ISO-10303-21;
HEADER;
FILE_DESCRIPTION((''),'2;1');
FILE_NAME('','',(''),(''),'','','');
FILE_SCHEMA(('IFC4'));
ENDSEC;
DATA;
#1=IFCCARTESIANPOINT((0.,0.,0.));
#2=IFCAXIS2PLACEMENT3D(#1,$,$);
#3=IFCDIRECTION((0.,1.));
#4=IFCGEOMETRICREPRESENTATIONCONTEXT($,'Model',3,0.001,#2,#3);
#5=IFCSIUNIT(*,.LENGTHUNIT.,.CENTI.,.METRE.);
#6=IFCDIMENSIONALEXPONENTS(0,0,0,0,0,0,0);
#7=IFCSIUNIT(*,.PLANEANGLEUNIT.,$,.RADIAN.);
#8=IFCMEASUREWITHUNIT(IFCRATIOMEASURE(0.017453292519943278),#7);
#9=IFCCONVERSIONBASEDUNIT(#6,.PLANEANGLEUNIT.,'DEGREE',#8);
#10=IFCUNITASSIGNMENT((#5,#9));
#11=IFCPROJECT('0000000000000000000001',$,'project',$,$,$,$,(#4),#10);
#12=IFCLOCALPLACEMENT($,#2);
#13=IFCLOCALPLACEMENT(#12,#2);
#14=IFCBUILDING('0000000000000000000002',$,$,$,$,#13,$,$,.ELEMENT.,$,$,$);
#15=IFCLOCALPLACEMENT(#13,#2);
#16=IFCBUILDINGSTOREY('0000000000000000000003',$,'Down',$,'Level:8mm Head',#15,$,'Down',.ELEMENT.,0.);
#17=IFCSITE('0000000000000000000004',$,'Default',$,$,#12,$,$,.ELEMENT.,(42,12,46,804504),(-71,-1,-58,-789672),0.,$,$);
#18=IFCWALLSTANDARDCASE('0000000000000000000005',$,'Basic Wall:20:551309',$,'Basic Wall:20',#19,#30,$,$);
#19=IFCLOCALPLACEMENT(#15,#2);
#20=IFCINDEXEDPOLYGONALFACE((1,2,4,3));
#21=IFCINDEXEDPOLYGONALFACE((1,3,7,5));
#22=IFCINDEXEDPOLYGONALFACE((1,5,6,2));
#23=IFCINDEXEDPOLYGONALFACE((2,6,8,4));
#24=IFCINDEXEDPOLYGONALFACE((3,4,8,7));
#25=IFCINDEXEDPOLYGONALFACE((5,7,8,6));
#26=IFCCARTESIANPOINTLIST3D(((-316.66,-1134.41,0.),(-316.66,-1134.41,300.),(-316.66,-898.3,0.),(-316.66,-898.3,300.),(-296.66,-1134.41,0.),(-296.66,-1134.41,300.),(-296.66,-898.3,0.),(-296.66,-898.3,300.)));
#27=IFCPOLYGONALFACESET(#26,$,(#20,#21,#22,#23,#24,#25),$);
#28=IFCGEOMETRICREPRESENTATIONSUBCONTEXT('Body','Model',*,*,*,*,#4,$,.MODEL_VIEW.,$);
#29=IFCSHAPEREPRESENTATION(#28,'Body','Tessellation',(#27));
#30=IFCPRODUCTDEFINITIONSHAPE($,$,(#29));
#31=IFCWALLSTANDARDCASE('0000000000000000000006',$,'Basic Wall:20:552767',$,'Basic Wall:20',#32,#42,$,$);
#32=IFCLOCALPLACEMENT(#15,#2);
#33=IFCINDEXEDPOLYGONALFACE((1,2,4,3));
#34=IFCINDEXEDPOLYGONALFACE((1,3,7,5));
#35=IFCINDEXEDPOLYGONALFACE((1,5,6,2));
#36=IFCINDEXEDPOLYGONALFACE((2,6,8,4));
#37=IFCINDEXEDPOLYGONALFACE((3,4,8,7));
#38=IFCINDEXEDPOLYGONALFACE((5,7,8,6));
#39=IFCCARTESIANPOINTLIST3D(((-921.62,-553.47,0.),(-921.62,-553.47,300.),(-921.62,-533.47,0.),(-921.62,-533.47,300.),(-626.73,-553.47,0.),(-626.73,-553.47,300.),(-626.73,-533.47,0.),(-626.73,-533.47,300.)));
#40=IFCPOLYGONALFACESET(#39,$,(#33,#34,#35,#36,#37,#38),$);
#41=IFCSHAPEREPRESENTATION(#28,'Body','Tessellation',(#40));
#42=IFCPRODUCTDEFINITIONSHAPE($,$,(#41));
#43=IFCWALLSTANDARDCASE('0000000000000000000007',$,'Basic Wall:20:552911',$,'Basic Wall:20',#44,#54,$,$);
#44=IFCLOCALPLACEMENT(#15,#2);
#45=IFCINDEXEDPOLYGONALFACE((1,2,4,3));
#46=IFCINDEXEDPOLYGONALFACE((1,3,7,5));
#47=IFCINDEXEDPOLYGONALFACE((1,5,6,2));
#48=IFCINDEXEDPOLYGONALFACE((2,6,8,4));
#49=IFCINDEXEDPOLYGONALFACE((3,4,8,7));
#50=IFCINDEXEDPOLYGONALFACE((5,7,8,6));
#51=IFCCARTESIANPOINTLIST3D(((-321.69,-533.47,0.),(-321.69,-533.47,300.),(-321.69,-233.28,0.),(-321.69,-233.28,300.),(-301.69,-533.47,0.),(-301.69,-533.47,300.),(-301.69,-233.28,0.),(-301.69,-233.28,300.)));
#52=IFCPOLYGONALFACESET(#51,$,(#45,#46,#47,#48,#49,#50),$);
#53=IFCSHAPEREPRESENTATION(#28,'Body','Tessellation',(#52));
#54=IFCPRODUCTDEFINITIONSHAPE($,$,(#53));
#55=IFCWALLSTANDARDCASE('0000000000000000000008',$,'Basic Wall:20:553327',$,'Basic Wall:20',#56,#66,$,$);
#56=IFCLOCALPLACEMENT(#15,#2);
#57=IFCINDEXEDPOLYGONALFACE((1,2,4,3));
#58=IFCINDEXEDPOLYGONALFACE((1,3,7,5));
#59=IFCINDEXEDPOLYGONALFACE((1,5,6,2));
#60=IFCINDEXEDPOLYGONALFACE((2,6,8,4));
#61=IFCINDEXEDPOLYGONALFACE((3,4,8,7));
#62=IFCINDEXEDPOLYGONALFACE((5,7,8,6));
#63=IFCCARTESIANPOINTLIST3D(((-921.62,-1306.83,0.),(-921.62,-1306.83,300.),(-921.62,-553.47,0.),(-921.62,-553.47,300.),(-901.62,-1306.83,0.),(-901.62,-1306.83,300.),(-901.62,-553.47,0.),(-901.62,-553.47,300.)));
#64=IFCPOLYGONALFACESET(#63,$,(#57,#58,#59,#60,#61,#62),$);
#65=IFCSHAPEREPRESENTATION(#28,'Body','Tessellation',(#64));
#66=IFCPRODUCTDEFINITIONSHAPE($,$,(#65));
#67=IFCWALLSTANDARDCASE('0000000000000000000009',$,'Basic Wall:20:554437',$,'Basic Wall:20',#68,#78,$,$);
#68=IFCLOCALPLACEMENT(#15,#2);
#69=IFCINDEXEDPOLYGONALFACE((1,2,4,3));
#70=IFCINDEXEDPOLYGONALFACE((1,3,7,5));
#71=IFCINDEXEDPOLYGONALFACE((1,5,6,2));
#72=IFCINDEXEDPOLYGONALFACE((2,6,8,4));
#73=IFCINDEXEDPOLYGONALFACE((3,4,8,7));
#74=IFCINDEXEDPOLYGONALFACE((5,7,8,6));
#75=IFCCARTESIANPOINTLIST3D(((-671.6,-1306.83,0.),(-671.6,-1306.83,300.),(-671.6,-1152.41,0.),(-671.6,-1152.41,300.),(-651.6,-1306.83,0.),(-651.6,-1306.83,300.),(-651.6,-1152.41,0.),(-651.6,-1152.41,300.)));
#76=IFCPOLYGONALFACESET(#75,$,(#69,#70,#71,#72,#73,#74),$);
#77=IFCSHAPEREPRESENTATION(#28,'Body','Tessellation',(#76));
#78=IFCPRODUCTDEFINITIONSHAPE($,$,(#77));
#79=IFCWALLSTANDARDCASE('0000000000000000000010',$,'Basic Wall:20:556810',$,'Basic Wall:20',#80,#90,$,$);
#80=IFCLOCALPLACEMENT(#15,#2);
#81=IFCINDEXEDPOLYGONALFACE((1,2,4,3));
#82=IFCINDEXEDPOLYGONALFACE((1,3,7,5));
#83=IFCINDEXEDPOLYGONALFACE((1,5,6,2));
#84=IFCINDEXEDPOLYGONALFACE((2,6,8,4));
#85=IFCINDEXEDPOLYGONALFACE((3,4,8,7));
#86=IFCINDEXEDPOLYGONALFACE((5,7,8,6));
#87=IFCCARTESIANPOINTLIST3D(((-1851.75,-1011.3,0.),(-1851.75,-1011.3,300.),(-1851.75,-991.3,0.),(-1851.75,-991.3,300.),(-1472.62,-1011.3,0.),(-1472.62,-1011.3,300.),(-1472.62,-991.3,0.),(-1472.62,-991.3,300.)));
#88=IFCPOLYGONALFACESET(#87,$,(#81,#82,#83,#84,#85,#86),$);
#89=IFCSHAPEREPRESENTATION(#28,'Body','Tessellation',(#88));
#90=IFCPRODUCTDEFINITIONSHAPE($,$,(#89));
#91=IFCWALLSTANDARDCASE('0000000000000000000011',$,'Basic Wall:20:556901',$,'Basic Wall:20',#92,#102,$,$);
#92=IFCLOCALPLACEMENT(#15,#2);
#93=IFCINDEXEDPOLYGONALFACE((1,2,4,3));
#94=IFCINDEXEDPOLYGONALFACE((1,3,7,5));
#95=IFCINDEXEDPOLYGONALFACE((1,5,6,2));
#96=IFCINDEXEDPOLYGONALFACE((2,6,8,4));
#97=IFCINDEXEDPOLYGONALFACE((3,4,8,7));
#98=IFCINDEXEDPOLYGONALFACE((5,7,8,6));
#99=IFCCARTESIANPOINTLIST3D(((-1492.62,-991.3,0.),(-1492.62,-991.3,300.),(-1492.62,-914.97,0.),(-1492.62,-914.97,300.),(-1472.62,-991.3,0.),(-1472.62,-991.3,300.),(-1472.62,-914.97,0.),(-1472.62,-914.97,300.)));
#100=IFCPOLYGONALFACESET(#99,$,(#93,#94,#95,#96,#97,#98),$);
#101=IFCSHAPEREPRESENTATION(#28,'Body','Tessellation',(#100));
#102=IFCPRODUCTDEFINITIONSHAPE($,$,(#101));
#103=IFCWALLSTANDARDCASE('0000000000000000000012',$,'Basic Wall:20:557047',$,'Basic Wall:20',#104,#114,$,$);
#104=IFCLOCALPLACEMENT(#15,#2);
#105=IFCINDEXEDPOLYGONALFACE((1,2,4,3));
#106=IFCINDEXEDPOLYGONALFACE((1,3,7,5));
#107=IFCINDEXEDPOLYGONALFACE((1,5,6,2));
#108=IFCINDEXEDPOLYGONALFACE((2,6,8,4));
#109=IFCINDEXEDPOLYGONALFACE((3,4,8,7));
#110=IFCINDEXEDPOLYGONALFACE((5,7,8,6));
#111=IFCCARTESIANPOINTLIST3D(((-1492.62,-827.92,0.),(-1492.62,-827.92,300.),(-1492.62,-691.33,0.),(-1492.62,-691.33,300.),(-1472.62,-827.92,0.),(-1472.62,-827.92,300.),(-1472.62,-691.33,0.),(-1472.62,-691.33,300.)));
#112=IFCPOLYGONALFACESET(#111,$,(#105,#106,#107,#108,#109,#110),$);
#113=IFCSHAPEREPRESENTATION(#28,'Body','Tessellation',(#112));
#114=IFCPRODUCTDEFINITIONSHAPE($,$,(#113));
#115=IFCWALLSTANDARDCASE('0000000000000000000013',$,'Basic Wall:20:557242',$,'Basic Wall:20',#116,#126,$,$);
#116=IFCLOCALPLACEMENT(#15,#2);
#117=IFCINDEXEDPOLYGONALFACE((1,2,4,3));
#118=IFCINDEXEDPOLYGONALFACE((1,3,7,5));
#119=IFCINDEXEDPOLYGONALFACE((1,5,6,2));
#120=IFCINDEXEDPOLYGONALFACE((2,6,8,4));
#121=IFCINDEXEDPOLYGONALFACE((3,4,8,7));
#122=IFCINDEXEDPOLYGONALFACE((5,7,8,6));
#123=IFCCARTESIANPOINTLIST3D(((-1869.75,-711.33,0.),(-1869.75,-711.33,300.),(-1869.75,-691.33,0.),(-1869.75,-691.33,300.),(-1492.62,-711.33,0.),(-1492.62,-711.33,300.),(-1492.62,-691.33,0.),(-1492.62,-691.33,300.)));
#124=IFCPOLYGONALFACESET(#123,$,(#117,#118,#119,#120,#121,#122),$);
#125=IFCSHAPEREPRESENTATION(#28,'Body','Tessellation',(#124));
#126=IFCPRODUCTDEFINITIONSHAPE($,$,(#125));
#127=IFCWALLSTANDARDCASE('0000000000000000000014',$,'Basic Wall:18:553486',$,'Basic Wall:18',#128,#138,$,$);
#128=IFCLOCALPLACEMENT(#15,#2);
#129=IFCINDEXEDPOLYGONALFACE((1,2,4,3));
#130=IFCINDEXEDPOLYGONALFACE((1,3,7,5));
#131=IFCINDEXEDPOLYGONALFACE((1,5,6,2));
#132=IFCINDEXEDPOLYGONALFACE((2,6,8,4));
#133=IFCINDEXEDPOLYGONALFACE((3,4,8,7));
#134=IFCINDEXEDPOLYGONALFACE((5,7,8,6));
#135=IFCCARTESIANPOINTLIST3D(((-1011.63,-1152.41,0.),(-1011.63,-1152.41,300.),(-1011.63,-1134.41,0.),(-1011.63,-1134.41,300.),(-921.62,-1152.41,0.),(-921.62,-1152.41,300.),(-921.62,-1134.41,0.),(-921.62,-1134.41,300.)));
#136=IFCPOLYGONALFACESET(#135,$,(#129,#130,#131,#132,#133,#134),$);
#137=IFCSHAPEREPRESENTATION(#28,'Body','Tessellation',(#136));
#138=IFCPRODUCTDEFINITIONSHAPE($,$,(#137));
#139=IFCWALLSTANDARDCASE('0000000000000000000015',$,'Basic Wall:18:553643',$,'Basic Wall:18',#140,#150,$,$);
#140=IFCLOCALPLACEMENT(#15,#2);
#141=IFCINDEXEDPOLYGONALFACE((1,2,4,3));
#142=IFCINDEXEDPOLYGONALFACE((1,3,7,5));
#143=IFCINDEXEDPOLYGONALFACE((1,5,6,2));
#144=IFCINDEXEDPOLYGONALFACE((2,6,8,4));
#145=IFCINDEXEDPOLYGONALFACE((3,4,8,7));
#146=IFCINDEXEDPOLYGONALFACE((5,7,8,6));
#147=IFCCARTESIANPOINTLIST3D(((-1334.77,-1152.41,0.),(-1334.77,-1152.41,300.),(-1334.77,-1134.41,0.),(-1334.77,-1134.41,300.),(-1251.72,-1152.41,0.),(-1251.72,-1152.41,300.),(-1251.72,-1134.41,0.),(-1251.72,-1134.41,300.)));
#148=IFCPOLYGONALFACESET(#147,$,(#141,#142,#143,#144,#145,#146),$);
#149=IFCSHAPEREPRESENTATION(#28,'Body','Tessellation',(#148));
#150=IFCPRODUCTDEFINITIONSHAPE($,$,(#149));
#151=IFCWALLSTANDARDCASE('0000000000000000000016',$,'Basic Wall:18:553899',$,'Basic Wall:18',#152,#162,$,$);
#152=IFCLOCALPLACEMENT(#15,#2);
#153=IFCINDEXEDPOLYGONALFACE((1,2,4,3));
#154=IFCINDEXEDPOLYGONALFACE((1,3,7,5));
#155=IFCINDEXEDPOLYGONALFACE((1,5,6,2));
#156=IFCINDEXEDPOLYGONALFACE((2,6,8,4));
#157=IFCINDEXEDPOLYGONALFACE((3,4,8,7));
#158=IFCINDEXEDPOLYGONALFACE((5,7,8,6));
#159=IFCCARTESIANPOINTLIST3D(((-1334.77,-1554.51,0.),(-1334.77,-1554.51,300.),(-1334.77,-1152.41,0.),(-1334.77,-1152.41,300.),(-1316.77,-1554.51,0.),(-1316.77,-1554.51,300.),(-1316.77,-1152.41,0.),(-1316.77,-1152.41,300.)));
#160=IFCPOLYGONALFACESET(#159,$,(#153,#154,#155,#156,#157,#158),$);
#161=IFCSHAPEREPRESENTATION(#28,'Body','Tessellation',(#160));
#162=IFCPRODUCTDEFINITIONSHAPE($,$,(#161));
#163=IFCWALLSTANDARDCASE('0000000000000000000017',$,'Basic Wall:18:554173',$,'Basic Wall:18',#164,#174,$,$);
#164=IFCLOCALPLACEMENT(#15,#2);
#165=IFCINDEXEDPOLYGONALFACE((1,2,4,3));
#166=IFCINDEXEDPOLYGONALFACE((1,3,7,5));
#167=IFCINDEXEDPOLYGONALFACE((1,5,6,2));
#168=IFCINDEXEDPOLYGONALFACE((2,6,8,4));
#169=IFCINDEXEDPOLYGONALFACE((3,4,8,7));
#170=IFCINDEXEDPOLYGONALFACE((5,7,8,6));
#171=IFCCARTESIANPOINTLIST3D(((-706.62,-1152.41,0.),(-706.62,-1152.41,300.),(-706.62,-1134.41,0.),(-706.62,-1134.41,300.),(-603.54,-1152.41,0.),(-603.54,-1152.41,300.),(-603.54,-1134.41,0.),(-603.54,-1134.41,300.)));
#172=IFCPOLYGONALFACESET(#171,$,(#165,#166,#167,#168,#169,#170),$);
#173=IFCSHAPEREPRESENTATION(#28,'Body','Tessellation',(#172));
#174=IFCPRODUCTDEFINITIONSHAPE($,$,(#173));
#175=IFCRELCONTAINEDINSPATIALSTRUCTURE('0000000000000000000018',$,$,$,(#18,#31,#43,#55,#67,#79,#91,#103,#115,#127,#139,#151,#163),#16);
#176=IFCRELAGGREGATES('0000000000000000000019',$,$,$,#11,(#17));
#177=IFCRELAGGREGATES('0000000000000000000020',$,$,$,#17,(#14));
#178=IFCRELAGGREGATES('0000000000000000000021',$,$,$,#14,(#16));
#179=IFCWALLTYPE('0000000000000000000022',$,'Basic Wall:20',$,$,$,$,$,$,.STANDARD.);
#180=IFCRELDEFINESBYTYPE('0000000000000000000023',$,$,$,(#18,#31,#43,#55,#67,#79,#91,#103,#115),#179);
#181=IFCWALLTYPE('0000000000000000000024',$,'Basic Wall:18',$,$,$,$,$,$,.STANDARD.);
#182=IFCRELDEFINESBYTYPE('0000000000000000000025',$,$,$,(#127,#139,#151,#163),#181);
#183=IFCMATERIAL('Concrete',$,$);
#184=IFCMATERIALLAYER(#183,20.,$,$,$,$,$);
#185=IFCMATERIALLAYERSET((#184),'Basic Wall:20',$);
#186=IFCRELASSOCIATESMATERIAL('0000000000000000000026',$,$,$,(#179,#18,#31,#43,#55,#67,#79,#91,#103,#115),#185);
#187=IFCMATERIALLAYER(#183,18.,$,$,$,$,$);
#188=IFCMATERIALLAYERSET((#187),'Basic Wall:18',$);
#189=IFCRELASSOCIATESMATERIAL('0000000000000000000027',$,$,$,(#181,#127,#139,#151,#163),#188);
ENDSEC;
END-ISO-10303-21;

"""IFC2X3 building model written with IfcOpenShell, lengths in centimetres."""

from ifc_helpers import new_model, entity, si_unit, converted_unit, direction, frame, frame_2d, origin, place, context, subcontext, project, spatial, rectangle, extrude, material, layer, layer_set, layer_usage, type_object, element, save


model = new_model("IFC2X3")

# Units and contexts
model_context = context("Model", 3, precision=0.001, world=origin(), true_north=direction((0.0, 1.0)))
body_context = subcontext(model_context, "Body", "Model", "MODEL_VIEW")
ifc_project = project(units=[si_unit("LENGTHUNIT", "METRE", prefix="CENTI"), converted_unit("PLANEANGLEUNIT", "DEGREE", entity("IfcRatioMeasure", 0.017453292519943278), si_unit("PLANEANGLEUNIT", "RADIAN"), dimensions=[0, 0, 0, 0, 0, 0, 0])], contexts=[model_context])

# Site, building, storey
site_placement = place(None, origin())
site = spatial("IfcSite", under=ifc_project, at=site_placement, Name="Default", CompositionType="ELEMENT", RefLatitude=(42, 12, 46, 804504), RefLongitude=(-71, -1, -58, -789672), RefElevation=0.0)
building_placement = place(site_placement, origin())
building = spatial("IfcBuilding", under=site, at=building_placement, CompositionType="ELEMENT")
storey_placement = place(building_placement, origin())
storey = spatial("IfcBuildingStorey", under=building, at=storey_placement, Name="Down", ObjectType="Level:8mm Head", LongName="Down", CompositionType="ELEMENT", Elevation=0.0)

# Walls
ifc_material = material(Name="Concrete")
ifc_layer_1 = layer(ifc_material, 20.0)
ifc_layer_set_1 = layer_set([ifc_layer_1], Name="Basic Wall:20")
ifc_layer_usage_1 = layer_usage(ifc_layer_set_1, "AXIS2", "POSITIVE", -10.0)
wall_type_1 = type_object("IfcWallType", Name="Basic Wall:20", PredefinedType="STANDARD", material=ifc_layer_set_1)
wall_1_placement = place(storey_placement, frame((-306.66, -898.3, 0.0), z_axis=(0.0, 0.0, 1.0), x_axis=(0.0, -1.0, 0.0)))
element("IfcWallStandardCase", 1, at=wall_1_placement, inside=storey, type_object=wall_type_1, material=ifc_layer_usage_1, Name="Basic Wall:20:551309", ObjectType="Basic Wall:20", context=body_context, shape_type="SweptSolid", body=[
    extrude(rectangle(XDim=236.11, YDim=20.0, at=frame_2d((118.05, 0.0), x_axis=(-1.0, 0.0))), origin(), (0.0, 0.0, 1.0), 300.0),
])
ifc_layer_usage_2 = layer_usage(ifc_layer_set_1, "AXIS2", "NEGATIVE", 10.0)
wall_2_placement = place(storey_placement, frame((-626.73, -543.47, 0.0), z_axis=(0.0, 0.0, 1.0), x_axis=(-1.0, 0.0, 0.0)))
element("IfcWallStandardCase", 2, at=wall_2_placement, inside=storey, type_object=wall_type_1, material=ifc_layer_usage_2, Name="Basic Wall:20:552767", ObjectType="Basic Wall:20", context=body_context, shape_type="SweptSolid", body=[
    extrude(rectangle(XDim=294.89, YDim=20.0, at=frame_2d((147.45, 0.0), x_axis=(-1.0, 0.0))), origin(), (0.0, 0.0, 1.0), 300.0),
])
ifc_layer_usage_3 = layer_usage(ifc_layer_set_1, "AXIS2", "NEGATIVE", 10.0)
wall_3_placement = place(storey_placement, frame((-311.69, -233.28, 0.0), z_axis=(0.0, 0.0, 1.0), x_axis=(0.0, -1.0, 0.0)))
element("IfcWallStandardCase", 3, at=wall_3_placement, inside=storey, type_object=wall_type_1, material=ifc_layer_usage_3, Name="Basic Wall:20:552911", ObjectType="Basic Wall:20", context=body_context, shape_type="SweptSolid", body=[
    extrude(rectangle(XDim=300.19, YDim=20.0, at=frame_2d((150.09, 0.0), x_axis=(-1.0, 0.0))), origin(), (0.0, 0.0, 1.0), 300.0),
])
ifc_layer_usage_4 = layer_usage(ifc_layer_set_1, "AXIS2", "POSITIVE", -10.0)
wall_4_placement = place(storey_placement, frame((-911.62, -553.47, 0.0), z_axis=(0.0, 0.0, 1.0), x_axis=(0.0, -1.0, 0.0)))
element("IfcWallStandardCase", 4, at=wall_4_placement, inside=storey, type_object=wall_type_1, material=ifc_layer_usage_4, Name="Basic Wall:20:553327", ObjectType="Basic Wall:20", context=body_context, shape_type="SweptSolid", body=[
    extrude(rectangle(XDim=753.36, YDim=20.0, at=frame_2d((376.68, 0.0), x_axis=(-1.0, 0.0))), origin(), (0.0, 0.0, 1.0), 300.0),
])
ifc_layer_usage_5 = layer_usage(ifc_layer_set_1, "AXIS2", "NEGATIVE", 10.0)
wall_5_placement = place(storey_placement, frame((-661.6, -1152.41, 0.0), z_axis=(0.0, 0.0, 1.0), x_axis=(0.0, -1.0, 0.0)))
element("IfcWallStandardCase", 5, at=wall_5_placement, inside=storey, type_object=wall_type_1, material=ifc_layer_usage_5, Name="Basic Wall:20:554437", ObjectType="Basic Wall:20", context=body_context, shape_type="SweptSolid", body=[
    extrude(rectangle(XDim=154.42, YDim=20.0, at=frame_2d((77.21, 0.0), x_axis=(-1.0, 0.0))), origin(), (0.0, 0.0, 1.0), 300.0),
])
ifc_layer_usage_6 = layer_usage(ifc_layer_set_1, "AXIS2", "POSITIVE", -10.0)
wall_6_placement = place(storey_placement, frame((-1851.75, -1001.3, 0.0)))
element("IfcWallStandardCase", 6, at=wall_6_placement, inside=storey, type_object=wall_type_1, material=ifc_layer_usage_6, Name="Basic Wall:20:556810", ObjectType="Basic Wall:20", context=body_context, shape_type="SweptSolid", body=[
    extrude(rectangle(XDim=379.13, YDim=20.0, at=frame_2d((189.56, 0.0), x_axis=(-1.0, 0.0))), origin(), (0.0, 0.0, 1.0), 300.0),
])
ifc_layer_usage_7 = layer_usage(ifc_layer_set_1, "AXIS2", "POSITIVE", -10.0)
wall_7_placement = place(storey_placement, frame((-1482.62, -991.3, 0.0), z_axis=(0.0, 0.0, 1.0), x_axis=(0.0, 1.0, 0.0)))
element("IfcWallStandardCase", 7, at=wall_7_placement, inside=storey, type_object=wall_type_1, material=ifc_layer_usage_7, Name="Basic Wall:20:556901", ObjectType="Basic Wall:20", context=body_context, shape_type="SweptSolid", body=[
    extrude(rectangle(XDim=76.33, YDim=20.0, at=frame_2d((38.17, 0.0), x_axis=(-1.0, 0.0))), origin(), (0.0, 0.0, 1.0), 300.0),
])
ifc_layer_usage_8 = layer_usage(ifc_layer_set_1, "AXIS2", "POSITIVE", -10.0)
wall_8_placement = place(storey_placement, frame((-1482.62, -827.92, 0.0), z_axis=(0.0, 0.0, 1.0), x_axis=(0.0, 1.0, 0.0)))
element("IfcWallStandardCase", 8, at=wall_8_placement, inside=storey, type_object=wall_type_1, material=ifc_layer_usage_8, Name="Basic Wall:20:557047", ObjectType="Basic Wall:20", context=body_context, shape_type="SweptSolid", body=[
    extrude(rectangle(XDim=136.59, YDim=20.0, at=frame_2d((68.3, 0.0), x_axis=(-1.0, 0.0))), origin(), (0.0, 0.0, 1.0), 300.0),
])
ifc_layer_usage_9 = layer_usage(ifc_layer_set_1, "AXIS2", "POSITIVE", -10.0)
wall_9_placement = place(storey_placement, frame((-1492.62, -701.33, 0.0), z_axis=(0.0, 0.0, 1.0), x_axis=(-1.0, 0.0, 0.0)))
element("IfcWallStandardCase", 9, at=wall_9_placement, inside=storey, type_object=wall_type_1, material=ifc_layer_usage_9, Name="Basic Wall:20:557242", ObjectType="Basic Wall:20", context=body_context, shape_type="SweptSolid", body=[
    extrude(rectangle(XDim=377.13, YDim=20.0, at=frame_2d((188.56, 0.0), x_axis=(-1.0, 0.0))), origin(), (0.0, 0.0, 1.0), 300.0),
])
ifc_layer_2 = layer(ifc_material, 18.0)
ifc_layer_set_2 = layer_set([ifc_layer_2], Name="Basic Wall:18")
ifc_layer_usage_10 = layer_usage(ifc_layer_set_2, "AXIS2", "POSITIVE", -9.0)
wall_type_2 = type_object("IfcWallType", Name="Basic Wall:18", PredefinedType="STANDARD", material=ifc_layer_set_2)
wall_10_placement = place(storey_placement, frame((-921.62, -1143.41, 0.0), z_axis=(0.0, 0.0, 1.0), x_axis=(-1.0, 0.0, 0.0)))
element("IfcWallStandardCase", 10, at=wall_10_placement, inside=storey, type_object=wall_type_2, material=ifc_layer_usage_10, Name="Basic Wall:18:553486", ObjectType="Basic Wall:18", context=body_context, shape_type="SweptSolid", body=[
    extrude(rectangle(XDim=90.01, YDim=18.0, at=frame_2d((45.0, 0.0), x_axis=(-1.0, 0.0))), origin(), (0.0, 0.0, 1.0), 300.0),
])
ifc_layer_usage_11 = layer_usage(ifc_layer_set_2, "AXIS2", "POSITIVE", -9.0)
wall_11_placement = place(storey_placement, frame((-1251.72, -1143.41, 0.0), z_axis=(0.0, 0.0, 1.0), x_axis=(-1.0, 0.0, 0.0)))
element("IfcWallStandardCase", 11, at=wall_11_placement, inside=storey, type_object=wall_type_2, material=ifc_layer_usage_11, Name="Basic Wall:18:553643", ObjectType="Basic Wall:18", context=body_context, shape_type="SweptSolid", body=[
    extrude(rectangle(XDim=83.05, YDim=18.0, at=frame_2d((41.53, 0.0), x_axis=(-1.0, 0.0))), origin(), (0.0, 0.0, 1.0), 300.0),
])
ifc_layer_usage_12 = layer_usage(ifc_layer_set_2, "AXIS2", "POSITIVE", -9.0)
wall_12_placement = place(storey_placement, frame((-1325.77, -1152.41, 0.0), z_axis=(0.0, 0.0, 1.0), x_axis=(0.0, -1.0, 0.0)))
element("IfcWallStandardCase", 12, at=wall_12_placement, inside=storey, type_object=wall_type_2, material=ifc_layer_usage_12, Name="Basic Wall:18:553899", ObjectType="Basic Wall:18", context=body_context, shape_type="SweptSolid", body=[
    extrude(rectangle(XDim=402.1, YDim=18.0, at=frame_2d((201.05, 0.0), x_axis=(-1.0, 0.0))), origin(), (0.0, 0.0, 1.0), 300.0),
])
ifc_layer_usage_13 = layer_usage(ifc_layer_set_2, "AXIS2", "POSITIVE", -9.0)
wall_13_placement = place(storey_placement, frame((-603.54, -1143.41, 0.0), z_axis=(0.0, 0.0, 1.0), x_axis=(-1.0, 0.0, 0.0)))
element("IfcWallStandardCase", 13, at=wall_13_placement, inside=storey, type_object=wall_type_2, material=ifc_layer_usage_13, Name="Basic Wall:18:554173", ObjectType="Basic Wall:18", context=body_context, shape_type="SweptSolid", body=[
    extrude(rectangle(XDim=103.08, YDim=18.0, at=frame_2d((51.54, 0.0), x_axis=(-1.0, 0.0))), origin(), (0.0, 0.0, 1.0), 300.0),
])

save(model, "model.ifc")
